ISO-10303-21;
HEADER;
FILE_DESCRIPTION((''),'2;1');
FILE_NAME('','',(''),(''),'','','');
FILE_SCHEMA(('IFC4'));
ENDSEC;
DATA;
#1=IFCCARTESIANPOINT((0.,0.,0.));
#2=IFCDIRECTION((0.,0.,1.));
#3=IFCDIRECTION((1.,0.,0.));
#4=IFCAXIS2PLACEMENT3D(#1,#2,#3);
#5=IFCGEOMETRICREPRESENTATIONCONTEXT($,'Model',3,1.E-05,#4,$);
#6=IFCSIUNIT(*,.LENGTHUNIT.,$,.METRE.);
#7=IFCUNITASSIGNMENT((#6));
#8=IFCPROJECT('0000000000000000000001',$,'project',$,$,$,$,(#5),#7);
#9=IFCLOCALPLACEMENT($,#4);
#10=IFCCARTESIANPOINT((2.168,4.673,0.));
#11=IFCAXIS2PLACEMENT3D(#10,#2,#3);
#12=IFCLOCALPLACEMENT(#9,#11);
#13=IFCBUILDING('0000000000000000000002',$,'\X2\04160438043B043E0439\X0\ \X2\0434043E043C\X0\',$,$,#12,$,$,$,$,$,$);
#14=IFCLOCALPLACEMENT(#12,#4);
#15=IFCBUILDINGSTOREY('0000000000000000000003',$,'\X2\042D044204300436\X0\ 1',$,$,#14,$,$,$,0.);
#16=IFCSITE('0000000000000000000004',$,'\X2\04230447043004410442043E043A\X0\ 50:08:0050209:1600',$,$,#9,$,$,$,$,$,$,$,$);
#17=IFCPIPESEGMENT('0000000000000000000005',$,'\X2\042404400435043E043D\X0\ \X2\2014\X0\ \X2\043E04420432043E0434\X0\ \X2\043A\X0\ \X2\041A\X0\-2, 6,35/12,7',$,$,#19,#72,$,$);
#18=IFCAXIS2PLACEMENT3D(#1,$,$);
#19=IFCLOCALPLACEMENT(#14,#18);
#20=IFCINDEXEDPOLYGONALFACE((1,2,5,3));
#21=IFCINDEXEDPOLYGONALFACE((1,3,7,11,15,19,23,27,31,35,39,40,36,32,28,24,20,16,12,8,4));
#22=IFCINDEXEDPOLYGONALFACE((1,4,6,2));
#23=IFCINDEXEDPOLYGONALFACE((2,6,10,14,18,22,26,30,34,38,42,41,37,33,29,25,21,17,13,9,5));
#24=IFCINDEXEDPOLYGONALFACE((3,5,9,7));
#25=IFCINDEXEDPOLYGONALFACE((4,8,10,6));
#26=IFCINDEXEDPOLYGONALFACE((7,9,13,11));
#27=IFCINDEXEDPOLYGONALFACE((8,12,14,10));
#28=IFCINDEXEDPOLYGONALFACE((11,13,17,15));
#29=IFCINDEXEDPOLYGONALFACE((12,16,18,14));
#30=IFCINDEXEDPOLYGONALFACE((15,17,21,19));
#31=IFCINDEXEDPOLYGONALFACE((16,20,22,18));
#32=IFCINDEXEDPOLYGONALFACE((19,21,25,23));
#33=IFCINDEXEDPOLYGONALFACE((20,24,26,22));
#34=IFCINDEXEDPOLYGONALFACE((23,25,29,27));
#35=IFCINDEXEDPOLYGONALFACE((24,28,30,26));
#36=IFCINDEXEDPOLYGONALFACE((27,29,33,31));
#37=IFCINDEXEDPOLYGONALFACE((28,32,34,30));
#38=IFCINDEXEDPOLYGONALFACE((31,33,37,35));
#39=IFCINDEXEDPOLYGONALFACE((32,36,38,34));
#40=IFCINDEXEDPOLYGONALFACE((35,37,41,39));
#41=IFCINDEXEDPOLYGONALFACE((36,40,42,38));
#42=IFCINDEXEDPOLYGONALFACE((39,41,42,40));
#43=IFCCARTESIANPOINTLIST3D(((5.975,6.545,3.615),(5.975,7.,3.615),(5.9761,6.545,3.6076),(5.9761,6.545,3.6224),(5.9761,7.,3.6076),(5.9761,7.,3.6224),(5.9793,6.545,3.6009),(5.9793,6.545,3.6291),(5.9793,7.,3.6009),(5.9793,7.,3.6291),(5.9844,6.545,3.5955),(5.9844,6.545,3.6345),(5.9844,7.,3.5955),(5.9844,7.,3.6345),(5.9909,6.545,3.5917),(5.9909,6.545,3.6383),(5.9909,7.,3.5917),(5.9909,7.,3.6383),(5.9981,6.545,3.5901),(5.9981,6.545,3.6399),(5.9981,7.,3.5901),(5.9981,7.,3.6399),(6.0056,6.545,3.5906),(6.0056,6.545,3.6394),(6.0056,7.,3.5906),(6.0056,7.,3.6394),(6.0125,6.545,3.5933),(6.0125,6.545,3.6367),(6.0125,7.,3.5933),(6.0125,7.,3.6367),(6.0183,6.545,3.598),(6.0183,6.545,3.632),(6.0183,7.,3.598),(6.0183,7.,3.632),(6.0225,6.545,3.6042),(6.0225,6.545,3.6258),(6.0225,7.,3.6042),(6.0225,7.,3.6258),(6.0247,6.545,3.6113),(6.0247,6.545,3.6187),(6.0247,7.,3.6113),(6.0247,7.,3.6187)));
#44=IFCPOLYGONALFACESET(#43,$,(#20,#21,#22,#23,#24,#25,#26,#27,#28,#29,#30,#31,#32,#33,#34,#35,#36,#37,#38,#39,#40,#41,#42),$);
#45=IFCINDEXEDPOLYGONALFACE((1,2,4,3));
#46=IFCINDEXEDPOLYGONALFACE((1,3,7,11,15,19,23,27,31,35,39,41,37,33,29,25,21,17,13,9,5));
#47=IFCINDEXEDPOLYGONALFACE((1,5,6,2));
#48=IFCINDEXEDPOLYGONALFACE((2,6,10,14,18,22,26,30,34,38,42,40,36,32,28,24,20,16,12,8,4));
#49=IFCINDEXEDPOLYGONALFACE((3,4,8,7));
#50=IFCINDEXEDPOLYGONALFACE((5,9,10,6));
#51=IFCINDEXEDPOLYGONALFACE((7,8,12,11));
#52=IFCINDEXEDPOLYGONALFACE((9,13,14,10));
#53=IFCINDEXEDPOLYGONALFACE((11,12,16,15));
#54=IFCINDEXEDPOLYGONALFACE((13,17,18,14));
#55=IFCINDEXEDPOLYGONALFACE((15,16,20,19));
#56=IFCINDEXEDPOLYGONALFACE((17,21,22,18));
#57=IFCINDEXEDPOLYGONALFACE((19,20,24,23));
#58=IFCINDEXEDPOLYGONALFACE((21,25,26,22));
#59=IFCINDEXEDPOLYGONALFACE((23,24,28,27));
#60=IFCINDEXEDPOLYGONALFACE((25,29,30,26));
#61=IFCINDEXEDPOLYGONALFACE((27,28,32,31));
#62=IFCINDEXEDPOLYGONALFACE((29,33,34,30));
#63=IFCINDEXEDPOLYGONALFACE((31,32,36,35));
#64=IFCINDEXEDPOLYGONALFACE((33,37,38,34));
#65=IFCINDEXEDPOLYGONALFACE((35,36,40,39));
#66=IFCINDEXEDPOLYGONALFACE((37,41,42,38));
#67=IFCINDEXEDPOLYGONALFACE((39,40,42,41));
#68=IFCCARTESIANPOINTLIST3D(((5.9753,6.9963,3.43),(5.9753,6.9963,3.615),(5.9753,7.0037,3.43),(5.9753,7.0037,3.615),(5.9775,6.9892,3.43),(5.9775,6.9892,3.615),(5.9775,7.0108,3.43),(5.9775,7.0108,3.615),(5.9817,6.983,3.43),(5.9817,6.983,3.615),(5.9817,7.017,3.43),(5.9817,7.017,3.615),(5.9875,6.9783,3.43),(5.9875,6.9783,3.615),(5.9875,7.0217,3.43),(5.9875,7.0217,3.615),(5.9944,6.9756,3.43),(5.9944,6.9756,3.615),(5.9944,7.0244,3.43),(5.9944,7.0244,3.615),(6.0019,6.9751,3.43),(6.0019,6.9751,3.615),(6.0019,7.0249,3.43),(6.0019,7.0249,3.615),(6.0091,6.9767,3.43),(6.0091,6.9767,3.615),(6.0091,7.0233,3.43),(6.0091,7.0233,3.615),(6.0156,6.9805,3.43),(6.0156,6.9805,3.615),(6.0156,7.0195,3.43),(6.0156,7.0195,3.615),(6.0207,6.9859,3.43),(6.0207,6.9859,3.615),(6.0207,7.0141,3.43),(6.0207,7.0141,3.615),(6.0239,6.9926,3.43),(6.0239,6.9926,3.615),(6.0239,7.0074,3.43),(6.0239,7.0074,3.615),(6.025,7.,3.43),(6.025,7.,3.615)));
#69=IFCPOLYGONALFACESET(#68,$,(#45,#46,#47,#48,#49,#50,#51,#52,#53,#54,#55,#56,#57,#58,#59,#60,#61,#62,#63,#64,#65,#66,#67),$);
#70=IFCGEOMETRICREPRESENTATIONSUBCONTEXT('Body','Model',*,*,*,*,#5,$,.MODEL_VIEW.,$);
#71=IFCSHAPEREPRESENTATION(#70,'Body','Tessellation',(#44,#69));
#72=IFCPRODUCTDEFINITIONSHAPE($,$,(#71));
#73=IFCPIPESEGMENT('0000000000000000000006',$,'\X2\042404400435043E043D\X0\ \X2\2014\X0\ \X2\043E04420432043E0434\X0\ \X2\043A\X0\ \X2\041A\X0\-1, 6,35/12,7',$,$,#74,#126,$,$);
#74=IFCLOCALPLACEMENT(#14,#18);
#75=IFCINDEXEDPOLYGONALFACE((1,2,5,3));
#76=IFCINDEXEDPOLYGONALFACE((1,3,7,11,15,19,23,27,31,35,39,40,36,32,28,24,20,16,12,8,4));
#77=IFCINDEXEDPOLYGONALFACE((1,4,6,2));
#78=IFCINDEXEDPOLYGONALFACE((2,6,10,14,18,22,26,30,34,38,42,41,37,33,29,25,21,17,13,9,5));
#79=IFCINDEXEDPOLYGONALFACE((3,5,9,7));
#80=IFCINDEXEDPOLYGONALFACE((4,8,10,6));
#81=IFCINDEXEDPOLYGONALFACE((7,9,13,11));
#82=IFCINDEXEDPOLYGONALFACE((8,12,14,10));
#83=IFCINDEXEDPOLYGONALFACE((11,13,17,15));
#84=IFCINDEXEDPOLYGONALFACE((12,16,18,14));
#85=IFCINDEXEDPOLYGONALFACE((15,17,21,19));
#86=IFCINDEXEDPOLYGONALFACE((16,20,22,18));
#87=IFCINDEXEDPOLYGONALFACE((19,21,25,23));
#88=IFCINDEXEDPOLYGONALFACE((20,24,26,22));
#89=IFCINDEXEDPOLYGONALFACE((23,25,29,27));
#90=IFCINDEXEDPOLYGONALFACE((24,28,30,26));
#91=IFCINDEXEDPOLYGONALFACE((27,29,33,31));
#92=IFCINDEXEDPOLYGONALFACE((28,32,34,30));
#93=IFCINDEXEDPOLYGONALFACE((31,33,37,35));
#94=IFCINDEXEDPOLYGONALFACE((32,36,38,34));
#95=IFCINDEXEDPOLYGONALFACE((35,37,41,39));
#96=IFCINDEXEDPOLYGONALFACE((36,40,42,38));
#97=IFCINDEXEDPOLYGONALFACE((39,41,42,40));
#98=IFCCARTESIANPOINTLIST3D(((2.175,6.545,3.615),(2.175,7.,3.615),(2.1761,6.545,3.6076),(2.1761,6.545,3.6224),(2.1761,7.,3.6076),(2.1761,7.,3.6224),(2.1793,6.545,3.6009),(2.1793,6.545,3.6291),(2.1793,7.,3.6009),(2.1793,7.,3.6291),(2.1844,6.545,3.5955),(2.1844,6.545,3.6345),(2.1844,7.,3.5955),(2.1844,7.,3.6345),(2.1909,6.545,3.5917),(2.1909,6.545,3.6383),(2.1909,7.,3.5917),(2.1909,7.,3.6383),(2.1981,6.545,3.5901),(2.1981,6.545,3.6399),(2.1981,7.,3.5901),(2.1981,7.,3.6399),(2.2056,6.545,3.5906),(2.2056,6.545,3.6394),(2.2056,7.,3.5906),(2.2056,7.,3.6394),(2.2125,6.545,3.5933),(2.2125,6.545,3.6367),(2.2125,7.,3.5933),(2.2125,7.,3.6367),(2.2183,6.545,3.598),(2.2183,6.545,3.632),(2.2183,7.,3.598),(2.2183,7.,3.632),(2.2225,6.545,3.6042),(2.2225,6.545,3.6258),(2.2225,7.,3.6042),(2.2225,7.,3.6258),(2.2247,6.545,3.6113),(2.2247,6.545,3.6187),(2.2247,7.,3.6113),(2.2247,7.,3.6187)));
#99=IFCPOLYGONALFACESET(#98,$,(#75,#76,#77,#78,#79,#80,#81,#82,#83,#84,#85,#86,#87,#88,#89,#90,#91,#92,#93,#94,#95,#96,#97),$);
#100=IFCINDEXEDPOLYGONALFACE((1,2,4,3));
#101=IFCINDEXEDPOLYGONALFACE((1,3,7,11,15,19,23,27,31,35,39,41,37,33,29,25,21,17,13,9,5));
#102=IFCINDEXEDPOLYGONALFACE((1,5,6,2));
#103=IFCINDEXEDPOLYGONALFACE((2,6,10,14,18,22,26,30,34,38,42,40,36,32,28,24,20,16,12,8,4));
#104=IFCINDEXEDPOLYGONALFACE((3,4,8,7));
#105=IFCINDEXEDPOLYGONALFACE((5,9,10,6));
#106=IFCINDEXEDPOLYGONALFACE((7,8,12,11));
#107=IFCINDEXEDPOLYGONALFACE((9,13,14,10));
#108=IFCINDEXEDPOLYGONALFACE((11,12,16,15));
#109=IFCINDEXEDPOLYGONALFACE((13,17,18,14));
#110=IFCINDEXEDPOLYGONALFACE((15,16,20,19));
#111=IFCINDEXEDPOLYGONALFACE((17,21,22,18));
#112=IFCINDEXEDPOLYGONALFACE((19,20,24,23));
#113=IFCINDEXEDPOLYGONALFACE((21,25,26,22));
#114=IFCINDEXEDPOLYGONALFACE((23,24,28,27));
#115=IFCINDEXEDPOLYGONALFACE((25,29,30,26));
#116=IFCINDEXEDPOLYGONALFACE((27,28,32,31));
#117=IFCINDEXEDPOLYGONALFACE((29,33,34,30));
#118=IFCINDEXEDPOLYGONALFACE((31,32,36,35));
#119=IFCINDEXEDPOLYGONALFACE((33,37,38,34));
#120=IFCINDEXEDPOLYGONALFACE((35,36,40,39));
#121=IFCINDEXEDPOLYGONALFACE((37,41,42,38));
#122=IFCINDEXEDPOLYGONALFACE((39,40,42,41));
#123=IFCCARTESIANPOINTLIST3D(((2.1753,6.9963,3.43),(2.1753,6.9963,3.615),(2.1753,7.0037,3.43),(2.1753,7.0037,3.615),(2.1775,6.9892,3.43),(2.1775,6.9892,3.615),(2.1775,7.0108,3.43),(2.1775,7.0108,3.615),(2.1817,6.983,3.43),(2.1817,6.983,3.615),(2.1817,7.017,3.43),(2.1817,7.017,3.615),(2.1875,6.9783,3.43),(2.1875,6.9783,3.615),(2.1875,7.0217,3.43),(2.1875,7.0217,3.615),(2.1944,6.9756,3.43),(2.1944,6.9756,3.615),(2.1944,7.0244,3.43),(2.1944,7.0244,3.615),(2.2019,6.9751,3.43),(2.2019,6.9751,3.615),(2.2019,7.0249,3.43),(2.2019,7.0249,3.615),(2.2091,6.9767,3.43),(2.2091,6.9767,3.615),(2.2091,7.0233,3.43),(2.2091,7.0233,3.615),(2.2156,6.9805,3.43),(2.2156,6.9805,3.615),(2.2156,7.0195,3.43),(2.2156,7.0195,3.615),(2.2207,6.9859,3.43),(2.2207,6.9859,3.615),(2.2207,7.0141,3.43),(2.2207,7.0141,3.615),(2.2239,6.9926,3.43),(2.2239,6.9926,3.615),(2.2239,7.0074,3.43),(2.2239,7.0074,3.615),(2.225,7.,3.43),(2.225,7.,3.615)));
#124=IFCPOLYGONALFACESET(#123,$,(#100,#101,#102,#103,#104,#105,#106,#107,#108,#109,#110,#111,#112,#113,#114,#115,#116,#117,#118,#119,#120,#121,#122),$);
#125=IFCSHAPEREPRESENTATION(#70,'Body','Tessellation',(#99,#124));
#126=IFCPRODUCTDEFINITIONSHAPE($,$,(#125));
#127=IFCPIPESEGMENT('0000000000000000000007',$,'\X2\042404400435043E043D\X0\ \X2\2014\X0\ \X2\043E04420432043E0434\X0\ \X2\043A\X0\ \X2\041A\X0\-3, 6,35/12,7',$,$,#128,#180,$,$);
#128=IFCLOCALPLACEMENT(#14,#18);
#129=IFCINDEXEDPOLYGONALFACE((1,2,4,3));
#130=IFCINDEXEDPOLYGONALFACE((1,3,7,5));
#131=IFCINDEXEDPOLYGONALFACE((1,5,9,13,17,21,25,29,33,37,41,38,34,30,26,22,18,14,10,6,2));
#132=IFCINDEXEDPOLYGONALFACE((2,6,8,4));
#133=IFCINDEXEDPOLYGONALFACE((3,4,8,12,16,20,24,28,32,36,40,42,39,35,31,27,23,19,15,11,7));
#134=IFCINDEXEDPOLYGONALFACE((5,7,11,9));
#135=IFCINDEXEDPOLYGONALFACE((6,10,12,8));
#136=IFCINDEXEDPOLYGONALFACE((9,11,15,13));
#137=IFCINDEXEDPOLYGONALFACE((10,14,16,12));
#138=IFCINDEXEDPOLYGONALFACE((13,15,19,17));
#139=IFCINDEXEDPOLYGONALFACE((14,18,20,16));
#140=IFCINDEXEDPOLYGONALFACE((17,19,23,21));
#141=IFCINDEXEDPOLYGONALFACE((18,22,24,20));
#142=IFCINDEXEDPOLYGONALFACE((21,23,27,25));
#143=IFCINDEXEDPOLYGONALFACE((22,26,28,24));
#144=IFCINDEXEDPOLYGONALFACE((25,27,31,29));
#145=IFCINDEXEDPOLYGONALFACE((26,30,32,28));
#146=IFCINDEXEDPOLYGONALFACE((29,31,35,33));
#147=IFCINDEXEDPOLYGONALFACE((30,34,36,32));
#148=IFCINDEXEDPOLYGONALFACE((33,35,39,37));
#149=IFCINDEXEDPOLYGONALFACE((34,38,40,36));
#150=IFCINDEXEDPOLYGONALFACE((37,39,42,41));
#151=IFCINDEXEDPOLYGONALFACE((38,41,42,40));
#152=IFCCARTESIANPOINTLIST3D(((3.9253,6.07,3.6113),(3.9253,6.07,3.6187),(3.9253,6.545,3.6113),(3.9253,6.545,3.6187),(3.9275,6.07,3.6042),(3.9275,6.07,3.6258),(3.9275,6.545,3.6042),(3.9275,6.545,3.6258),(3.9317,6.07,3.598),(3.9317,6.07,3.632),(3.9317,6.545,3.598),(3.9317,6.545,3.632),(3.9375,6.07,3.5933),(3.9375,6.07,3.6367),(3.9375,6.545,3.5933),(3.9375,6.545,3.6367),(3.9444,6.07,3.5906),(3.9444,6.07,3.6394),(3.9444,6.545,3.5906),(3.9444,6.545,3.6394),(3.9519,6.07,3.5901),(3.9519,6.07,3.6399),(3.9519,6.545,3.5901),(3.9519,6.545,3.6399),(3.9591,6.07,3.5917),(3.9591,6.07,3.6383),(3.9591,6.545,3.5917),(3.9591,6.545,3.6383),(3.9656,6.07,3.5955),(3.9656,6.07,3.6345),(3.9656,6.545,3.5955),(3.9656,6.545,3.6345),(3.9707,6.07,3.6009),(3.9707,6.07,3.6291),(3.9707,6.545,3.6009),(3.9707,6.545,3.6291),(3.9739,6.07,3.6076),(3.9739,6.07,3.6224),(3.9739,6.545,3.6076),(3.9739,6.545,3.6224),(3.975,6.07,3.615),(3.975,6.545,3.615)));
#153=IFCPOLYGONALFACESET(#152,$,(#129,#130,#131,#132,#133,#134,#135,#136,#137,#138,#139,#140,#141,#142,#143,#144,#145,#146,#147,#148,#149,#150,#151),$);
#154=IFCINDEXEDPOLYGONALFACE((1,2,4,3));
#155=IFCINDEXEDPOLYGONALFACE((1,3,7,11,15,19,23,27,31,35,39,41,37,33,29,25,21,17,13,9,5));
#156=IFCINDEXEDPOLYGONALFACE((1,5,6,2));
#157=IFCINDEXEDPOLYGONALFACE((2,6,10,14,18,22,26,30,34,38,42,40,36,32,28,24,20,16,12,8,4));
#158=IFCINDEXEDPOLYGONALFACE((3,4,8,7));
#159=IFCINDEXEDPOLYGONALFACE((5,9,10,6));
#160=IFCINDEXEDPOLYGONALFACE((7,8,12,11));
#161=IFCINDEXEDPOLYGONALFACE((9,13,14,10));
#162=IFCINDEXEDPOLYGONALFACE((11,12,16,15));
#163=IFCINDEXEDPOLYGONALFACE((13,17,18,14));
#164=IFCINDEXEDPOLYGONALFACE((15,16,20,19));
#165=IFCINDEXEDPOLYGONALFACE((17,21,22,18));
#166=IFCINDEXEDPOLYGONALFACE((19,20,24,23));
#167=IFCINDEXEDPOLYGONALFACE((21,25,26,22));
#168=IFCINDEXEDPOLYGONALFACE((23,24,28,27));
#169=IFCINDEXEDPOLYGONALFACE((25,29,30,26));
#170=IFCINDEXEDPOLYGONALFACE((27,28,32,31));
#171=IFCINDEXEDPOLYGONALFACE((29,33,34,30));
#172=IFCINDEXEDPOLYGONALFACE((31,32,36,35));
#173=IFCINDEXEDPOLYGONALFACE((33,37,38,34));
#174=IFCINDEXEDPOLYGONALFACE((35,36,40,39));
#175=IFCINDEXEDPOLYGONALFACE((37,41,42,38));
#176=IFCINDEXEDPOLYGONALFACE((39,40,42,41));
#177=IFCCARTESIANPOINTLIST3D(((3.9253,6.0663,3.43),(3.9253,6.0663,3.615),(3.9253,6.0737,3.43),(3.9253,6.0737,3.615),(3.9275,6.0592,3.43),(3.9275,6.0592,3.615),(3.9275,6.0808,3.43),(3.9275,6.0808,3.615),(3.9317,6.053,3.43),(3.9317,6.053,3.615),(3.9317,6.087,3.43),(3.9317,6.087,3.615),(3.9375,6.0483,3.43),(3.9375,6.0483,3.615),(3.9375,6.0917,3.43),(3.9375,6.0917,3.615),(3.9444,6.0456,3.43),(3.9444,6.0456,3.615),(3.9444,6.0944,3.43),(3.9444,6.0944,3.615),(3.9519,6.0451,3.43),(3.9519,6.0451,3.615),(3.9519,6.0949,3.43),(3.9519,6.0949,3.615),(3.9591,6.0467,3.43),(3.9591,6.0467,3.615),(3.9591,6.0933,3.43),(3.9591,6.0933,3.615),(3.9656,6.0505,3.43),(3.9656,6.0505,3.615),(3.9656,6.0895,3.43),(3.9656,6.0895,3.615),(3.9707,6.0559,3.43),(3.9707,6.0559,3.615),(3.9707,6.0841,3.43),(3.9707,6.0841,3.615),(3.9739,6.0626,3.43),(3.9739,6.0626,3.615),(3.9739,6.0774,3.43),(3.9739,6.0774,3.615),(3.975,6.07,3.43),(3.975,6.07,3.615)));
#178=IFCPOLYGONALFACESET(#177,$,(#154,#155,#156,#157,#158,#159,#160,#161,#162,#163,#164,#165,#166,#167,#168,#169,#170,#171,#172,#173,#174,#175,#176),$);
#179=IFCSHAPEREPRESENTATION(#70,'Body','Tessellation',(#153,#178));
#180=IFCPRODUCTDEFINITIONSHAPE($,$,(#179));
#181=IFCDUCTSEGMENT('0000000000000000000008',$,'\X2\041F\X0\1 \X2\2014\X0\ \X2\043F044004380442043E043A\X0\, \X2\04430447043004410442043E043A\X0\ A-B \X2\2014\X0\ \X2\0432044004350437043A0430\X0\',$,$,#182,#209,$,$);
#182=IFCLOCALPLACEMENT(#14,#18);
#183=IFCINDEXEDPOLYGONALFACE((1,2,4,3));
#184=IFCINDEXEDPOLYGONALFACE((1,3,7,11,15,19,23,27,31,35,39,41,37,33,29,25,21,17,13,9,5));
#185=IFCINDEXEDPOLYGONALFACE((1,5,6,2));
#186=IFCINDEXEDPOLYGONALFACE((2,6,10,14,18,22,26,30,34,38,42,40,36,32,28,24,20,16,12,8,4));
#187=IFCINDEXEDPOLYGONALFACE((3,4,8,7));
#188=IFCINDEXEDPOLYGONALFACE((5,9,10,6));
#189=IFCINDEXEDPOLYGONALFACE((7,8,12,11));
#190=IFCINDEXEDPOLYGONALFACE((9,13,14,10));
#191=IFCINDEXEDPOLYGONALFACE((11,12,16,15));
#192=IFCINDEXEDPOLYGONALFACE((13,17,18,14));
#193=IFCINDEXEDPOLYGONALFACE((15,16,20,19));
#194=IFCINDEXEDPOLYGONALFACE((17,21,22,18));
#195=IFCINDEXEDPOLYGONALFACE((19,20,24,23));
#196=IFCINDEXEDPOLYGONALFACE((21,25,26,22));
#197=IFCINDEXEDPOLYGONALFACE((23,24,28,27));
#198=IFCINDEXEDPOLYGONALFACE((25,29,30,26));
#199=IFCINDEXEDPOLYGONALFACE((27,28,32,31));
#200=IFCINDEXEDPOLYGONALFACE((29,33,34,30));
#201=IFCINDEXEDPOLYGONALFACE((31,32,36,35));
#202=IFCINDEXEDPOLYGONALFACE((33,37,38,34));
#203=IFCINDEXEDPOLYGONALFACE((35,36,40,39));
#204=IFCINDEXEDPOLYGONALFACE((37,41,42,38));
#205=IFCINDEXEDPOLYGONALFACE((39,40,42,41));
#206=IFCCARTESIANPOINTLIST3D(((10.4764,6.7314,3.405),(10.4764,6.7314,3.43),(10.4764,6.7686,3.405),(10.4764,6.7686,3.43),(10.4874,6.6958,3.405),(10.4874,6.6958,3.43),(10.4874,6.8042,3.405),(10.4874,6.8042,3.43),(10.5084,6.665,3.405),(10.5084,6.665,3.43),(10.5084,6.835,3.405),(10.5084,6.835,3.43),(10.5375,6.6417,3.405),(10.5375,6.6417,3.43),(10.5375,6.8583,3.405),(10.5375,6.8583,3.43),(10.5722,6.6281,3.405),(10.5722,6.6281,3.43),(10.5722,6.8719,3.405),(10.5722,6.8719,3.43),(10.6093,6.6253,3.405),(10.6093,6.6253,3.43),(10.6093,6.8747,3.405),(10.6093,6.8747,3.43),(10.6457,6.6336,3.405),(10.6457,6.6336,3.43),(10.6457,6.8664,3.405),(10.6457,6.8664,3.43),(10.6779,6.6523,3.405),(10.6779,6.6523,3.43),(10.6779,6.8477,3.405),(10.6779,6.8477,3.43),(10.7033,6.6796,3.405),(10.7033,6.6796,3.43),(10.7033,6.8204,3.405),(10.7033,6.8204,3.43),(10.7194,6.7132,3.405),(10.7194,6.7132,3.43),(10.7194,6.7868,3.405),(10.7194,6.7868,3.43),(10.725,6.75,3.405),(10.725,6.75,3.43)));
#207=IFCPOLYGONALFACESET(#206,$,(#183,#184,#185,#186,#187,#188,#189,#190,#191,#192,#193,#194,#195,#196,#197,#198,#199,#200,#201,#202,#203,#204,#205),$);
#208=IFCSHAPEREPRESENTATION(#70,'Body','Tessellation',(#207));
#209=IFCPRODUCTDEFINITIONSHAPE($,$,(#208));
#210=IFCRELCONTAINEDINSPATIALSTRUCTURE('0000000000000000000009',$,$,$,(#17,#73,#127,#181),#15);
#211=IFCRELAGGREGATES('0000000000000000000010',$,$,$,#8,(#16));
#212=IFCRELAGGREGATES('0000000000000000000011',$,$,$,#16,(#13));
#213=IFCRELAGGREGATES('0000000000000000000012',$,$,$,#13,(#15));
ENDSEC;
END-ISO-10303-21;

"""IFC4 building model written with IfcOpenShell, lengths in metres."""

from ifc_helpers import new_model, si_unit, frame, origin_with_axes, origin_2d, place, context, subcontext, project, spatial, circle, extrude, element, save


model = new_model("IFC4")

# Units and contexts
model_context = context("Model", 3, precision=1e-05, world=origin_with_axes())
body_context = subcontext(model_context, "Body", "Model", "MODEL_VIEW")
ifc_project = project(units=[si_unit("LENGTHUNIT", "METRE")], contexts=[model_context])

# Site, building, storey
site_placement = place(None, origin_with_axes())
site = spatial("IfcSite", under=ifc_project, at=site_placement, Name="Участок 50:08:0050209:1600")
building_placement = place(site_placement, frame((2.168, 4.673, 0.0), z_axis=(0.0, 0.0, 1.0), x_axis=(1.0, 0.0, 0.0)))
building = spatial("IfcBuilding", under=site, at=building_placement, Name="Жилой дом")
storey_placement = place(building_placement, origin_with_axes())
storey = spatial("IfcBuildingStorey", under=building, at=storey_placement, Name="Этаж 1", Elevation=0.0)

# Pipe segments
pipe_segment_1_placement = place(storey_placement, origin_with_axes())
element("IfcPipeSegment", 1, at=pipe_segment_1_placement, inside=storey, Name="Фреон — отвод к К-2, 6,35/12,7", context=body_context, shape_type="SweptSolid", body=[
    extrude(circle(Radius=0.025, at=origin_2d()), frame((6.0, 6.545, 3.615), z_axis=(0.0, 1.0, 0.0), x_axis=(-1.0, 0.0, 0.0)), (0.0, 0.0, 1.0), 0.455),
    extrude(circle(Radius=0.025, at=origin_2d()), frame((6.0, 7.0, 3.615), z_axis=(0.0, 0.0, -1.0), x_axis=(1.0, 0.0, 0.0)), (0.0, 0.0, 1.0), 0.185),
])
pipe_segment_2_placement = place(storey_placement, origin_with_axes())
element("IfcPipeSegment", 2, at=pipe_segment_2_placement, inside=storey, Name="Фреон — отвод к К-1, 6,35/12,7", context=body_context, shape_type="SweptSolid", body=[
    extrude(circle(Radius=0.025, at=origin_2d()), frame((2.2, 6.545, 3.615), z_axis=(0.0, 1.0, 0.0), x_axis=(-1.0, 0.0, 0.0)), (0.0, 0.0, 1.0), 0.455),
    extrude(circle(Radius=0.025, at=origin_2d()), frame((2.2, 7.0, 3.615), z_axis=(0.0, 0.0, -1.0), x_axis=(1.0, 0.0, 0.0)), (0.0, 0.0, 1.0), 0.185),
])
pipe_segment_3_placement = place(storey_placement, origin_with_axes())
element("IfcPipeSegment", 3, at=pipe_segment_3_placement, inside=storey, Name="Фреон — отвод к К-3, 6,35/12,7", context=body_context, shape_type="SweptSolid", body=[
    extrude(circle(Radius=0.025, at=origin_2d()), frame((3.95, 6.545, 3.615), z_axis=(0.0, -1.0, 0.0), x_axis=(1.0, 0.0, 0.0)), (0.0, 0.0, 1.0), 0.475),
    extrude(circle(Radius=0.025, at=origin_2d()), frame((3.95, 6.07, 3.615), z_axis=(0.0, 0.0, -1.0), x_axis=(1.0, 0.0, 0.0)), (0.0, 0.0, 1.0), 0.185),
])

# Duct segment
duct_segment_1_placement = place(storey_placement, origin_with_axes())
element("IfcDuctSegment", 4, at=duct_segment_1_placement, inside=storey, Name="П1 — приток, участок A-B — врезка", context=body_context, shape_type="SweptSolid", body=[
    extrude(circle(Radius=0.125, at=origin_2d()), frame((10.6, 6.75, 3.405), z_axis=(0.0, 0.0, 1.0), x_axis=(1.0, 0.0, 0.0)), (0.0, 0.0, 1.0), 0.025),
])

save(model, "model.ifc")
